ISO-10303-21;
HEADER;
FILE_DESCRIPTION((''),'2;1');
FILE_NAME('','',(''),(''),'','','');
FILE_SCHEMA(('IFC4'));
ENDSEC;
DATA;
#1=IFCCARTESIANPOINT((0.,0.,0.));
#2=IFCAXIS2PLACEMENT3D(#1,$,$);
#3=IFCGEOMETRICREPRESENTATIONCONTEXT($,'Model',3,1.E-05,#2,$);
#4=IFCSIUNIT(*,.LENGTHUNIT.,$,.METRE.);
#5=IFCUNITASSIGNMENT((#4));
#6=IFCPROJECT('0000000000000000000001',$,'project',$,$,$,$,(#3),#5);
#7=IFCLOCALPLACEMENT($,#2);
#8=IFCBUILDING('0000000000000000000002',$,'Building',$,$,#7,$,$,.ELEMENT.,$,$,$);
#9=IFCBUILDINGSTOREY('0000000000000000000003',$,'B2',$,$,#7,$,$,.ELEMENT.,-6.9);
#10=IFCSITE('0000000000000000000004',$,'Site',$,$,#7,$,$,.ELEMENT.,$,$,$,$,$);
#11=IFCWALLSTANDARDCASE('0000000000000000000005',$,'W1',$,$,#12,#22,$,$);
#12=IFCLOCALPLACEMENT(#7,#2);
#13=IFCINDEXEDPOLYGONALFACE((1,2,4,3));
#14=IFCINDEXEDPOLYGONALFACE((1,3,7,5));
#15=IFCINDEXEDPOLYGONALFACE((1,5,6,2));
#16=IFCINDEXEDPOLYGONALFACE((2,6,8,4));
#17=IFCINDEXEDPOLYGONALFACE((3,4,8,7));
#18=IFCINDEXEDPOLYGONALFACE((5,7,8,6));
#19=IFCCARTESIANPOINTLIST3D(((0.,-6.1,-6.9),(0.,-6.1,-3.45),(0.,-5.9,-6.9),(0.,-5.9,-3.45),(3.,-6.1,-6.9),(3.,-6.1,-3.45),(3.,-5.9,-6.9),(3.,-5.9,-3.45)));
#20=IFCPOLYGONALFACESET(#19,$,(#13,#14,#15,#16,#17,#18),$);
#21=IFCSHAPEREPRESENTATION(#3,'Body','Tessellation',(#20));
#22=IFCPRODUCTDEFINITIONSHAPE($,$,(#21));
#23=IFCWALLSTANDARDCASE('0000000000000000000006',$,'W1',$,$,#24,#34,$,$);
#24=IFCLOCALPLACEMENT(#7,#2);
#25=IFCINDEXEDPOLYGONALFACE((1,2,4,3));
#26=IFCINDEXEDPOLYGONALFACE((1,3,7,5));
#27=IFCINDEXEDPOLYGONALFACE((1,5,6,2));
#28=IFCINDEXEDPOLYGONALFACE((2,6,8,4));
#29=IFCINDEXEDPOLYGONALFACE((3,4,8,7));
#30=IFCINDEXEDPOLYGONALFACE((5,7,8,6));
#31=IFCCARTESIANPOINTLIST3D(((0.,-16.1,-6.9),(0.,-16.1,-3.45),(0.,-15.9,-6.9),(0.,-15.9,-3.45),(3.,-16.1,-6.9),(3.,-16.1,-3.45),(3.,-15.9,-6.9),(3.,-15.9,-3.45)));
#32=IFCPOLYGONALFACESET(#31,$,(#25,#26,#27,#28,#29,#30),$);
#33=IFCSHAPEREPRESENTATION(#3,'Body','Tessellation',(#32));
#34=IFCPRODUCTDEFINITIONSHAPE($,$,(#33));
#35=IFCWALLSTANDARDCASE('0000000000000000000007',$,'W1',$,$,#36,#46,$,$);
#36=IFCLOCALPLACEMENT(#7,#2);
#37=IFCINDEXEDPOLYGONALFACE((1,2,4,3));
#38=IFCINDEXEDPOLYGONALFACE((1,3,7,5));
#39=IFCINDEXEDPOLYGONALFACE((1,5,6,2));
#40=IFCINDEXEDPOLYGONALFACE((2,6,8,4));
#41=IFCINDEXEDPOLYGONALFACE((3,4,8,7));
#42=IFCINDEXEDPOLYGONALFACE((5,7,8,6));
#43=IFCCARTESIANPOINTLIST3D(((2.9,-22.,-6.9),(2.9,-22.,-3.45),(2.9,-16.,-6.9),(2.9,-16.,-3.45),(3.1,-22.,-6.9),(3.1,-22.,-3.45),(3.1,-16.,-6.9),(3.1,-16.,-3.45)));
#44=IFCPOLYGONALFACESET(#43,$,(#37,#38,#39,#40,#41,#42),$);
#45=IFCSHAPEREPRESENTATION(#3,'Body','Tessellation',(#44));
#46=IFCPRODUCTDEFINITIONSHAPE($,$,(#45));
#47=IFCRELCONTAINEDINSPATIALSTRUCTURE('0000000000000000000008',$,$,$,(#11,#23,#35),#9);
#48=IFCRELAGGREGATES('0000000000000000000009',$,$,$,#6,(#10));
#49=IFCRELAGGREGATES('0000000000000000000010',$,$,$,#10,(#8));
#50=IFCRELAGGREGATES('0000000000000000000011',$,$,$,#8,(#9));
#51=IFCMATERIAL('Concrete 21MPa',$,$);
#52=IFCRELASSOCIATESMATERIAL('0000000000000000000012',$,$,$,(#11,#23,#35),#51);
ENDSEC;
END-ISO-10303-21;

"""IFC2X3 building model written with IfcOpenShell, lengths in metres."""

from ifc_helpers import new_model, si_unit, frame, origin, origin_2d, place, context, project, spatial, rectangle, extrude, material, element, save


model = new_model("IFC2X3")

# Units and contexts
model_context = context("Model", 3, precision=1e-05, world=origin())
ifc_project = project(units=[si_unit("LENGTHUNIT", "METRE")], contexts=[model_context])

# Site, building, storey
placement = place(None, origin())
site = spatial("IfcSite", under=ifc_project, at=placement, Name="Site", CompositionType="ELEMENT")
building = spatial("IfcBuilding", under=site, at=placement, Name="Building", CompositionType="ELEMENT")
storey = spatial("IfcBuildingStorey", under=building, at=placement, Name="B2", CompositionType="ELEMENT", Elevation=-6.9)

# Shared definitions
ifc_material = material(Name="Concrete 21MPa")

# Walls
for number, where, name in (
    (1, (1.5, -6.0, -6.9), "W1"),
    (2, (1.5, -16.0, -6.9), "W1"),
):
    element("IfcWallStandardCase", number, at=place(None, frame(where)), inside=storey, material=ifc_material, Name=name, context=model_context, shape_type="SweptSolid", body=[
        extrude(rectangle(XDim=3.0, YDim=0.2, at=origin_2d()), origin(), (0.0, 0.0, 1.0), 3.45),
    ])
wall_1_placement = place(None, frame((3.0, -19.0, -6.9)))
element("IfcWallStandardCase", 3, at=wall_1_placement, inside=storey, material=ifc_material, Name="W1", context=model_context, shape_type="SweptSolid", body=[
    extrude(rectangle(XDim=0.2, YDim=6.0, at=origin_2d()), origin(), (0.0, 0.0, 1.0), 3.45),
])

save(model, "model.ifc")
